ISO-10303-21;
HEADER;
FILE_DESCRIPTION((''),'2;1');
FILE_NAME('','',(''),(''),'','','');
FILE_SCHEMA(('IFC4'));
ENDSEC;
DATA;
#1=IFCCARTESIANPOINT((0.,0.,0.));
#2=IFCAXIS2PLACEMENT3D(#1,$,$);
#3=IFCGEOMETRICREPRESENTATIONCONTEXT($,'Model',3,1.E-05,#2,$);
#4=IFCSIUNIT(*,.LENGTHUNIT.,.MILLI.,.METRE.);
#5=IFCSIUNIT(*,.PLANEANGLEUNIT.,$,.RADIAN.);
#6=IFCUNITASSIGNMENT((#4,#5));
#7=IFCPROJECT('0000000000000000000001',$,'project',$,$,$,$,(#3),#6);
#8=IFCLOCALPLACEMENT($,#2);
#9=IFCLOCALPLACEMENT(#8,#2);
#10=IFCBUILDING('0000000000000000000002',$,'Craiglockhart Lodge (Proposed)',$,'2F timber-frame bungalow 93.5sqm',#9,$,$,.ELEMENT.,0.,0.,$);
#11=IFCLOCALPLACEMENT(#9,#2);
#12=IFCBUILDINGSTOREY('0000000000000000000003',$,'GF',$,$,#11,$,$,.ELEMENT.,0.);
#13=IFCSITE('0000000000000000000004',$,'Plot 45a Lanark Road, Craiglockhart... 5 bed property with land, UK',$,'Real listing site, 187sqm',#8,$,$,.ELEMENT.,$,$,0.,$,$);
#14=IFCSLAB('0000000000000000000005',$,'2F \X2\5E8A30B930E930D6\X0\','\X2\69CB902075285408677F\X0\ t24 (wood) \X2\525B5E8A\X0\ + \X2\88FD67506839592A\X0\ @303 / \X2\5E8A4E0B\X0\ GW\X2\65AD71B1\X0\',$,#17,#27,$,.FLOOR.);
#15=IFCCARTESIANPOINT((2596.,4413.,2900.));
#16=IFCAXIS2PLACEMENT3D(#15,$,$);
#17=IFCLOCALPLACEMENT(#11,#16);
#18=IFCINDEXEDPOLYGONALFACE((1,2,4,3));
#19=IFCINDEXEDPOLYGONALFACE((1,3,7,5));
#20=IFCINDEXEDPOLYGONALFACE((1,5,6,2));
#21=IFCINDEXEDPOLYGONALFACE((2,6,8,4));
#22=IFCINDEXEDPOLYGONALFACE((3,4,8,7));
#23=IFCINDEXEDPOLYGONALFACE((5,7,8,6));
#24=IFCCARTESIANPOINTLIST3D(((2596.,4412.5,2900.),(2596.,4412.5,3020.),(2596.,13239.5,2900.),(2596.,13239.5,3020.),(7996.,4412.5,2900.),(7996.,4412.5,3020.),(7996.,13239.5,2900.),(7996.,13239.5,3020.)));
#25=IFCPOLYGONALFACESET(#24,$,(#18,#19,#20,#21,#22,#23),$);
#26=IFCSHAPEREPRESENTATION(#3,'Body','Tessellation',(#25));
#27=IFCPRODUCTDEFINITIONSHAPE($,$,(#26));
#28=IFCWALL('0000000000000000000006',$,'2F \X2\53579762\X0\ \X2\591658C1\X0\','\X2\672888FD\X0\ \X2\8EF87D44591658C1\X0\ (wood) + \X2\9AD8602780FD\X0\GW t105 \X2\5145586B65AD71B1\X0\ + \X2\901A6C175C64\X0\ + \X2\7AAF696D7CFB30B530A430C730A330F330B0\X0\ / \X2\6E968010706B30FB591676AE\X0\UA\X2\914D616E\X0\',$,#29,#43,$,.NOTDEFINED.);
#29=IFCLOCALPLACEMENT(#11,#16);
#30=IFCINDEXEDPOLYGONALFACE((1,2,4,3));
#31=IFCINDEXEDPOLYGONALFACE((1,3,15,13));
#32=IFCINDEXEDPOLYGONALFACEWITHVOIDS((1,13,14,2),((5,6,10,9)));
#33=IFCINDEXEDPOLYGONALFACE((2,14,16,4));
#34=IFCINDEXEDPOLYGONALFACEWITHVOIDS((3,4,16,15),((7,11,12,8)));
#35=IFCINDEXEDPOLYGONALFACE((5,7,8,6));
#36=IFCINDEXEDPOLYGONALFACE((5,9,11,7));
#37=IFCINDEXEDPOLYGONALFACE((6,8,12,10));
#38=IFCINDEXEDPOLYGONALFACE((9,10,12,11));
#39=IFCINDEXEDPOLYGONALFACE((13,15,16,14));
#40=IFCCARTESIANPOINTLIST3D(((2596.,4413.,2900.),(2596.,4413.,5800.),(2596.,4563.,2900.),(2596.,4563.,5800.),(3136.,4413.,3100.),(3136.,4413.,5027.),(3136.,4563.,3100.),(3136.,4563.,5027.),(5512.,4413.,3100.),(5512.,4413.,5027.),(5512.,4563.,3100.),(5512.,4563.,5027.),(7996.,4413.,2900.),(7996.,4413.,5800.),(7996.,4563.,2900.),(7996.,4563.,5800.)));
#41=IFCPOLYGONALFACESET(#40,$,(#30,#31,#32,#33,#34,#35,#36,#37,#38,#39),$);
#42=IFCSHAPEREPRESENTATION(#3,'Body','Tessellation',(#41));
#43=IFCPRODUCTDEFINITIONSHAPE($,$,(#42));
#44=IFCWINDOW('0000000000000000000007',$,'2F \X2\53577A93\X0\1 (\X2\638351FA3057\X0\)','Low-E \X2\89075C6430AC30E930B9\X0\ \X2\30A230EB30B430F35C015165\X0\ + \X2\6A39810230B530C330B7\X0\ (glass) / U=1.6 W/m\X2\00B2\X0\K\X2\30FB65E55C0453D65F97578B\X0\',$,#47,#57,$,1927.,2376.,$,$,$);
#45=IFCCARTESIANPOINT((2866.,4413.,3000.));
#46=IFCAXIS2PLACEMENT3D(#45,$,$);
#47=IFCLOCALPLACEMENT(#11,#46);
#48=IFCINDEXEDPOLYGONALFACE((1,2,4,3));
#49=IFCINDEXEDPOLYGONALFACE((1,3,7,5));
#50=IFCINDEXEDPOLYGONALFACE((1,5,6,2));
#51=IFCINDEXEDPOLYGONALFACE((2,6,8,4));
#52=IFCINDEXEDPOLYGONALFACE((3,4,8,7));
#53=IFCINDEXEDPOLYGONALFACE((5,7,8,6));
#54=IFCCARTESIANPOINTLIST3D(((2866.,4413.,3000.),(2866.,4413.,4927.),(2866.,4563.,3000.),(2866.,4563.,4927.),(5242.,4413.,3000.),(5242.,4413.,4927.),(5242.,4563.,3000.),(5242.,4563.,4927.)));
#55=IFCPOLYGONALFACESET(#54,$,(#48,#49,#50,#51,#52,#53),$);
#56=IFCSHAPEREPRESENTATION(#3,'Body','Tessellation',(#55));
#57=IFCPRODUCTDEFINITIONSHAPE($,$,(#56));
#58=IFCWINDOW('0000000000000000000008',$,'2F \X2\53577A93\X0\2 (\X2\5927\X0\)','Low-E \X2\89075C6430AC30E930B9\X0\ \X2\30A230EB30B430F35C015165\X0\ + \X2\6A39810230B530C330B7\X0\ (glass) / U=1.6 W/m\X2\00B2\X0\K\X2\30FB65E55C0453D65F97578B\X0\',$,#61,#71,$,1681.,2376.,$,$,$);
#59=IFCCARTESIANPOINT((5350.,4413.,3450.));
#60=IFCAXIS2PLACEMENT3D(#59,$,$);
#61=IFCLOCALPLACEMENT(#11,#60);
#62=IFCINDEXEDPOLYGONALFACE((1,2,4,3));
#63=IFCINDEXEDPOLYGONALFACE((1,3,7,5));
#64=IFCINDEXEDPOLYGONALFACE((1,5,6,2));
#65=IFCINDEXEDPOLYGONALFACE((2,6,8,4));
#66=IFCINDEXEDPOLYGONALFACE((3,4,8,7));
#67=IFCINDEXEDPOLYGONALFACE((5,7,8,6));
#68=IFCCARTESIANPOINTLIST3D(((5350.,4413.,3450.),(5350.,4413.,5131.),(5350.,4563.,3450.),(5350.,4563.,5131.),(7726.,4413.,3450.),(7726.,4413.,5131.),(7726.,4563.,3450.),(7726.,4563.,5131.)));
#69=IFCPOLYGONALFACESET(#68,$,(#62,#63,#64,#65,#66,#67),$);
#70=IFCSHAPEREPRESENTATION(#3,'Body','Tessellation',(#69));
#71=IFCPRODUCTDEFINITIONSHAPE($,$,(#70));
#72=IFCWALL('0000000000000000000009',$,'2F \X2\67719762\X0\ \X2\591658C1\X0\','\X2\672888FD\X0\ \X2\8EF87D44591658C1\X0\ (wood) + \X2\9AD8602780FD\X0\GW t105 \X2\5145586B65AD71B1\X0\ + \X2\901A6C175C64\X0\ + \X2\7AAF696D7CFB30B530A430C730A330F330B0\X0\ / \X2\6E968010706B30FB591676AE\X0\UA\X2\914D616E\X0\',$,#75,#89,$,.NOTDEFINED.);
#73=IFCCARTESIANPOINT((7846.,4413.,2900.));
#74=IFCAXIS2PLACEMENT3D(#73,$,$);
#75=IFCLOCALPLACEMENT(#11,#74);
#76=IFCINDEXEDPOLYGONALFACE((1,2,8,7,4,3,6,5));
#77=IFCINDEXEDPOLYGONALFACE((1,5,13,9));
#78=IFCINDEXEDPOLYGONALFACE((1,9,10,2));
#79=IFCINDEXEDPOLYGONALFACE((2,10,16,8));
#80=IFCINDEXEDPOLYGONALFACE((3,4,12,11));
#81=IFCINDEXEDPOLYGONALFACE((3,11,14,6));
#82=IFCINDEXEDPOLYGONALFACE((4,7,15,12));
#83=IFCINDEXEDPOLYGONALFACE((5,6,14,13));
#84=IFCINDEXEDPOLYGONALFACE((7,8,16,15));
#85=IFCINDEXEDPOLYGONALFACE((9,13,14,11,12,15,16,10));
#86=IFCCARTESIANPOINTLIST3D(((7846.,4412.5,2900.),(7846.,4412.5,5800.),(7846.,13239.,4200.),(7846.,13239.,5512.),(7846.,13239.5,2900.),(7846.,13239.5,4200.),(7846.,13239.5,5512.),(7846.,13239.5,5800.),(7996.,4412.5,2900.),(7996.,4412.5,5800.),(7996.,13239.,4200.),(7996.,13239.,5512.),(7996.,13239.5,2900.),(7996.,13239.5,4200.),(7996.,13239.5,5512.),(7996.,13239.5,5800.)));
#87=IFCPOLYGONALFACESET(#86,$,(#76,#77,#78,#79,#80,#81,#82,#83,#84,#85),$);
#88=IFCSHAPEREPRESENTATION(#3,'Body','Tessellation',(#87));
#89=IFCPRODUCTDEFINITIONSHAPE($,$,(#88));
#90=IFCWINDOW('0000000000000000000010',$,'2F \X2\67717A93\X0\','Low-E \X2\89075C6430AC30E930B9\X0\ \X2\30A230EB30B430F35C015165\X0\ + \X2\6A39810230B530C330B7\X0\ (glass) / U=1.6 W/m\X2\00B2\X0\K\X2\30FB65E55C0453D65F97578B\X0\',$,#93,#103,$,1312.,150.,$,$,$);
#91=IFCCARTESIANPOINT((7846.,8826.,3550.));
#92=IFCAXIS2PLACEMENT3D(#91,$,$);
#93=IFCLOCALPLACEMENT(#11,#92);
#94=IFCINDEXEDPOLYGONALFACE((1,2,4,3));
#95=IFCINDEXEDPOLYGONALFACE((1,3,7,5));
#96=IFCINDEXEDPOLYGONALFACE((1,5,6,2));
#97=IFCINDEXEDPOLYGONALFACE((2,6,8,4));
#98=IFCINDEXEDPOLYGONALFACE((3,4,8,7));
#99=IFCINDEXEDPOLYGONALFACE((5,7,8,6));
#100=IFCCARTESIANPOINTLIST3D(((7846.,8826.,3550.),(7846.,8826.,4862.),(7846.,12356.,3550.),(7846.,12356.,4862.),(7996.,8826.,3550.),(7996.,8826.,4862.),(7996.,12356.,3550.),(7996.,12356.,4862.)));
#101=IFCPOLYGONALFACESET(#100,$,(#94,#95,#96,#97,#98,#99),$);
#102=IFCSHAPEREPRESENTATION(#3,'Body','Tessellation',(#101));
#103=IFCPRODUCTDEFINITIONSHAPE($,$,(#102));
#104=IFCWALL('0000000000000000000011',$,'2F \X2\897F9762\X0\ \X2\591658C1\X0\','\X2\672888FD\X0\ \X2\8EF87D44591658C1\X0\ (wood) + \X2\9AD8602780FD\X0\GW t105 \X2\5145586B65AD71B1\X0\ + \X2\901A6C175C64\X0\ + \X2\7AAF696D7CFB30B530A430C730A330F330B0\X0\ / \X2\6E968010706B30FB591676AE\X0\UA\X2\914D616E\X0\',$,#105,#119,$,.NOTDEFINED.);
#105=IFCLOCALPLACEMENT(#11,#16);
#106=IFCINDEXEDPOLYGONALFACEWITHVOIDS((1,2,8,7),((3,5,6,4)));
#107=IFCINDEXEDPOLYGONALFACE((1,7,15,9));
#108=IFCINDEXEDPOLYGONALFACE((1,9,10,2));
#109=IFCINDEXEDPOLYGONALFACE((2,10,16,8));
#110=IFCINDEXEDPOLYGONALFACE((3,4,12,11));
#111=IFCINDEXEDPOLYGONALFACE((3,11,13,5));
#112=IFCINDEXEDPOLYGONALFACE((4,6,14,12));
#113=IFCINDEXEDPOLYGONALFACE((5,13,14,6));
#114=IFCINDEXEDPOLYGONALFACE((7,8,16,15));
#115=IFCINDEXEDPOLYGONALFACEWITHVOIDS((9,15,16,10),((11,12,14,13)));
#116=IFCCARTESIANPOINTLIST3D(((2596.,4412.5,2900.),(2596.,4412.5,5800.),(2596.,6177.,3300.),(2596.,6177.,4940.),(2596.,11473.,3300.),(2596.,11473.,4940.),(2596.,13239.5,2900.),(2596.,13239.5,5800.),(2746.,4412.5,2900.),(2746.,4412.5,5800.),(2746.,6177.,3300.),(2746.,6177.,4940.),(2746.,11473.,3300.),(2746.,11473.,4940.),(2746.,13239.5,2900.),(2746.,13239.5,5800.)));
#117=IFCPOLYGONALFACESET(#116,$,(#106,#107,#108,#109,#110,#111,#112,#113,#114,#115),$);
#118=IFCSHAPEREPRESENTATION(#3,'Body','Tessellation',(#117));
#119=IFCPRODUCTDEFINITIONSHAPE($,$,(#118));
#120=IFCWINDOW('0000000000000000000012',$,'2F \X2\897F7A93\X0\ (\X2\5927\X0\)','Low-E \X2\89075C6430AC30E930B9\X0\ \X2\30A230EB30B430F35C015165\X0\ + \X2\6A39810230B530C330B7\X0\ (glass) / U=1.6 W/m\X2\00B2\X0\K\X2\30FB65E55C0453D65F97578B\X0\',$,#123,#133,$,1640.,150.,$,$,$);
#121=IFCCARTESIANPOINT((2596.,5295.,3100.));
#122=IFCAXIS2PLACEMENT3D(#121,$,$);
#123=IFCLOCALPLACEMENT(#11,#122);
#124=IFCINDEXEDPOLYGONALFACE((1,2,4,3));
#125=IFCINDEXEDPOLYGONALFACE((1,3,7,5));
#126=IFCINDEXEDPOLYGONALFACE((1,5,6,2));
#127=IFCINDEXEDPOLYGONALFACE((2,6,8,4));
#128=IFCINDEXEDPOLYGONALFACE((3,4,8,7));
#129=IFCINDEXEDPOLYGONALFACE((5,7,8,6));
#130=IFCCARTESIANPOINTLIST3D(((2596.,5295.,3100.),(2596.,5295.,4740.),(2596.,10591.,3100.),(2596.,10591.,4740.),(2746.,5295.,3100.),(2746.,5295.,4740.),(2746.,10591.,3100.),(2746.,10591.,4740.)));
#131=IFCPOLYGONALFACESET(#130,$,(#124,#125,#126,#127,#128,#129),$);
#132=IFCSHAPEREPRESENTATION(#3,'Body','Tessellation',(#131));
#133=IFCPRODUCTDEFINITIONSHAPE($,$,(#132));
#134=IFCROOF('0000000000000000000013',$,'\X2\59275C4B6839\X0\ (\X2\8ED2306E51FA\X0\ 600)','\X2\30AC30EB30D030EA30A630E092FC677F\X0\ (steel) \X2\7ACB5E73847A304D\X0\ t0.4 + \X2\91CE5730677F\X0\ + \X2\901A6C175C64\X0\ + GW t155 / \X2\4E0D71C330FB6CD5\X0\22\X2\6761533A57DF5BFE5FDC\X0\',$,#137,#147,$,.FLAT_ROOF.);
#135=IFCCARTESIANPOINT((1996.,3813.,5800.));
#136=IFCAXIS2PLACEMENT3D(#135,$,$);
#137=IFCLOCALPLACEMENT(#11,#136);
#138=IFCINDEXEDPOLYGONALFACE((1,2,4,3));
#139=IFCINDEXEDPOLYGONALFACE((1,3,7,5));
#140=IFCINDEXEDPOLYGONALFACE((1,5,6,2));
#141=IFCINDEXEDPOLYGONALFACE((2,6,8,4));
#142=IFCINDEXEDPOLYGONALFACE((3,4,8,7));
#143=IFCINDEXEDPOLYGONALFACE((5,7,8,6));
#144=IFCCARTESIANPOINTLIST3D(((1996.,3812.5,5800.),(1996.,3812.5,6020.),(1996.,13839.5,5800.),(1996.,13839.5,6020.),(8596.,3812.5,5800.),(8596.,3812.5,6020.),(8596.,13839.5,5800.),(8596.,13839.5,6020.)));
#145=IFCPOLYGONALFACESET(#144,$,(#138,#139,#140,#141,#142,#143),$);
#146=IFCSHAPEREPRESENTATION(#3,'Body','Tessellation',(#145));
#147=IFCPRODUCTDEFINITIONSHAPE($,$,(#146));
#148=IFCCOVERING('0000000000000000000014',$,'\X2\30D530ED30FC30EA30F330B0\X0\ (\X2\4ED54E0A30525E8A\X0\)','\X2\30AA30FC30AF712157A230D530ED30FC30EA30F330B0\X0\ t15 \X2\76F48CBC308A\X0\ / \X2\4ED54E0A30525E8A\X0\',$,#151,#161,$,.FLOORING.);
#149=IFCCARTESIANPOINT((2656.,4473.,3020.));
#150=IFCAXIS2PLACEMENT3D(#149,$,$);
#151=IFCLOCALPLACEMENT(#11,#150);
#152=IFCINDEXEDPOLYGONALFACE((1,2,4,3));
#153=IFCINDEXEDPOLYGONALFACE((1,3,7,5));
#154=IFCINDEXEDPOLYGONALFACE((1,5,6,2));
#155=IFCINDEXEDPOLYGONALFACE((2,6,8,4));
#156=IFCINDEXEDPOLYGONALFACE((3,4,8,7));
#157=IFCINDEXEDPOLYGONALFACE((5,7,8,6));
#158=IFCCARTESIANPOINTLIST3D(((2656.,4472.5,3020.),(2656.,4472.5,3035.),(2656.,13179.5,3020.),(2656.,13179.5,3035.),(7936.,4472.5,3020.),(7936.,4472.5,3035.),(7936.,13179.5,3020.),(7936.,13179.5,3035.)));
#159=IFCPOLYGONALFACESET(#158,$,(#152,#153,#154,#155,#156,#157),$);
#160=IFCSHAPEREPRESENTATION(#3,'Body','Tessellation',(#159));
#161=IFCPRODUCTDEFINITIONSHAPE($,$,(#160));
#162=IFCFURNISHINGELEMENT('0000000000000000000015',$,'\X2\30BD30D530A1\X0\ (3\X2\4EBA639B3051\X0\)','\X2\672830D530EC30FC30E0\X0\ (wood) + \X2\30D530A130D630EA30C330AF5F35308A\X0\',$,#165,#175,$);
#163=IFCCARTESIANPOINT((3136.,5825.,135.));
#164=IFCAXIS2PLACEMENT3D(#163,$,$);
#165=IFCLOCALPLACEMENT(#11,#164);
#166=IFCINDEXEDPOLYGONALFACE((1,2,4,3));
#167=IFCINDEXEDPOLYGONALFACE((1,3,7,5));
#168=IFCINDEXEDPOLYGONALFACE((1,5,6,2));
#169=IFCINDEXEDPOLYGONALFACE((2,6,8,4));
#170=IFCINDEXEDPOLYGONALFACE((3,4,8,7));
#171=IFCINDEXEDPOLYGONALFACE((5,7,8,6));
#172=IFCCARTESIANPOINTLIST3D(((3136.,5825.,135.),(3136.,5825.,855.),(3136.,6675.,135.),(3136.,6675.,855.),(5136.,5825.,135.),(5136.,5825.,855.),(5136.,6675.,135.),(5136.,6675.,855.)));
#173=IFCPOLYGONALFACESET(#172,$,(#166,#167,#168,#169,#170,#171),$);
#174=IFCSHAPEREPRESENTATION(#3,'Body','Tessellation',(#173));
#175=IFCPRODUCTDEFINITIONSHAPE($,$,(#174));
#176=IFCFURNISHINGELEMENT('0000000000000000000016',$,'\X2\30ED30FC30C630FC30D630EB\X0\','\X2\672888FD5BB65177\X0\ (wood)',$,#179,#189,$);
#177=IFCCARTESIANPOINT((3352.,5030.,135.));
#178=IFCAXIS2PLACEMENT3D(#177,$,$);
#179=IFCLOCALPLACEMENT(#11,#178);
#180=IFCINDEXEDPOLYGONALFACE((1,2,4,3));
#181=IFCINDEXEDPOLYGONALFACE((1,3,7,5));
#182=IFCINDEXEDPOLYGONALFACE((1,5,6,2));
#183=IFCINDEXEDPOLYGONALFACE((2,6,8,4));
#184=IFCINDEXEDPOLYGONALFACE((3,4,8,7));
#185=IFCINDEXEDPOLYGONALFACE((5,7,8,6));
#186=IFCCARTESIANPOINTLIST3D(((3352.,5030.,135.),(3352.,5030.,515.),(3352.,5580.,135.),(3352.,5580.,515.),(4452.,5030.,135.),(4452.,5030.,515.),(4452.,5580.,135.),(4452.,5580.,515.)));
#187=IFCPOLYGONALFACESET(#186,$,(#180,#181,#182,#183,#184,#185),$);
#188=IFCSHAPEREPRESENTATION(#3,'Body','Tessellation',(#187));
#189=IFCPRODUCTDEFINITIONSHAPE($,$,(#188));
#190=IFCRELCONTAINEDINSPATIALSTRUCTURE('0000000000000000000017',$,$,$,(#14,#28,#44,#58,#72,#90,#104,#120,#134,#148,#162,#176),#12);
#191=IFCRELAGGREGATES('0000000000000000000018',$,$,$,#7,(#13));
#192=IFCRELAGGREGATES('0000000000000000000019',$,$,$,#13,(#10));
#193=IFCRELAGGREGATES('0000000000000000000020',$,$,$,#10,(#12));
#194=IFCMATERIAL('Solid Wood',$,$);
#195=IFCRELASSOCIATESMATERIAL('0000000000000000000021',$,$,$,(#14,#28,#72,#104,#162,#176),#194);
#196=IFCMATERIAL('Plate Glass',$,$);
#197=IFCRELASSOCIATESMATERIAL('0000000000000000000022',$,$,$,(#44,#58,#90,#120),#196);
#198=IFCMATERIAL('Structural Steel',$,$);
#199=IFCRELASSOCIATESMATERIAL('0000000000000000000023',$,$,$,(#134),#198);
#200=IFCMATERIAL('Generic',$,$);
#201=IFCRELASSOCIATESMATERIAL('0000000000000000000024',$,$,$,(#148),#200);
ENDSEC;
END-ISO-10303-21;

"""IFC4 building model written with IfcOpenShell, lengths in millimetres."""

from ifc_helpers import new_model, si_unit, frame, frame_2d, origin, place, context, project, spatial, rectangle, extrude, material, element, fill, save


model = new_model("IFC4")

# Units and contexts
model_context = context("Model", 3, precision=1e-05, world=origin())
ifc_project = project(units=[si_unit("LENGTHUNIT", "METRE", prefix="MILLI"), si_unit("PLANEANGLEUNIT", "RADIAN")], contexts=[model_context])

# Site, building, storey
site_placement = place(None, origin())
site = spatial("IfcSite", under=ifc_project, at=site_placement, Name="Plot 45a Lanark Road, Craiglockhart... 5 bed property with land, UK", ObjectType="Real listing site, 187sqm", CompositionType="ELEMENT", RefElevation=0.0)
building_placement = place(site_placement, origin())
building = spatial("IfcBuilding", under=site, at=building_placement, Name="Craiglockhart Lodge (Proposed)", ObjectType="2F timber-frame bungalow 93.5sqm", CompositionType="ELEMENT", ElevationOfRefHeight=0.0, ElevationOfTerrain=0.0)
storey_placement = place(building_placement, origin())
storey = spatial("IfcBuildingStorey", under=building, at=storey_placement, Name="GF", CompositionType="ELEMENT", Elevation=0.0)

# Slab
ifc_material_1 = material(Name="Solid Wood")
slab_placement = place(storey_placement, frame((2596.0, 4413.0, 2900.0)))
element("IfcSlab", 1, at=slab_placement, inside=storey, material=ifc_material_1, Name="2F 床スラブ", Description="構造用合板 t24 (wood) 剛床 + 製材根太 @303 / 床下 GW断熱", PredefinedType="FLOOR", context=model_context, shape_type="SweptSolid", body=[
    extrude(rectangle(XDim=5400.0, YDim=8827.0, at=frame_2d((2700.0, 4413.0))), frame((2596.0, 4413.0, 2900.0)), (0.0, 0.0, 1.0), 120.0),
])

# Wall, openings, windows
wall_1_placement = place(storey_placement, frame((2596.0, 4413.0, 2900.0)))
wall_1 = element("IfcWall", 2, at=wall_1_placement, inside=storey, material=ifc_material_1, Name="2F 南面 外壁", Description="木製 軸組外壁 (wood) + 高性能GW t105 充填断熱 + 通気層 + 窯業系サイディング / 準耐火・外皮UA配慮", PredefinedType="NOTDEFINED", context=model_context, shape_type="SweptSolid", body=[
    extrude(rectangle(XDim=5400.0, YDim=150.0, at=frame_2d((2700.0, 75.0))), frame((2596.0, 4413.0, 2900.0)), (0.0, 0.0, 1.0), 2900.0),
])
opening_1_placement = place(storey_placement, frame((2866.0, 4413.0, 3000.0)))
opening_1 = element("IfcOpeningElement", 3, at=opening_1_placement, cuts=wall_1, PredefinedType="NOTDEFINED", context=model_context, shape_type="SweptSolid", body=[
    extrude(rectangle(XDim=2376.0, YDim=150.0, at=frame_2d((1188.0, 75.0))), frame((2866.0, 4413.0, 3000.0)), (0.0, 0.0, 1.0), 1927.0),
])
opening_2_placement = place(storey_placement, frame((5350.0, 4413.0, 3450.0)))
opening_2 = element("IfcOpeningElement", 4, at=opening_2_placement, cuts=wall_1, PredefinedType="NOTDEFINED", context=model_context, shape_type="SweptSolid", body=[
    extrude(rectangle(XDim=2376.0, YDim=150.0, at=frame_2d((1188.0, 75.0))), frame((5350.0, 4413.0, 3450.0)), (0.0, 0.0, 1.0), 1681.0),
])
ifc_material_2 = material(Name="Plate Glass")
window_1_placement = place(storey_placement, frame((2866.0, 4413.0, 3000.0)))
window_1 = element("IfcWindow", 5, at=window_1_placement, inside=storey, material=ifc_material_2, Name="2F 南窓1 (掃出し)", Description="Low-E 複層ガラス アルゴン封入 + 樹脂サッシ (glass) / U=1.6 W/m²K・日射取得型", OverallHeight=1927.0, OverallWidth=2376.0, context=model_context, shape_type="SweptSolid", body=[
    extrude(rectangle(XDim=2376.0, YDim=150.0, at=frame_2d((1188.0, 75.0))), frame((2866.0, 4413.0, 3000.0)), (0.0, 0.0, 1.0), 1927.0),
])
fill(opening_1, window_1)
window_2_placement = place(storey_placement, frame((5350.0, 4413.0, 3450.0)))
window_2 = element("IfcWindow", 6, at=window_2_placement, inside=storey, material=ifc_material_2, Name="2F 南窓2 (大)", Description="Low-E 複層ガラス アルゴン封入 + 樹脂サッシ (glass) / U=1.6 W/m²K・日射取得型", OverallHeight=1681.0, OverallWidth=2376.0, context=model_context, shape_type="SweptSolid", body=[
    extrude(rectangle(XDim=2376.0, YDim=150.0, at=frame_2d((1188.0, 75.0))), frame((5350.0, 4413.0, 3450.0)), (0.0, 0.0, 1.0), 1681.0),
])
fill(opening_2, window_2)

# Walls, openings, windows
wall_2_placement = place(storey_placement, frame((7846.0, 4413.0, 2900.0)))
wall_2 = element("IfcWall", 7, at=wall_2_placement, inside=storey, material=ifc_material_1, Name="2F 東面 外壁", Description="木製 軸組外壁 (wood) + 高性能GW t105 充填断熱 + 通気層 + 窯業系サイディング / 準耐火・外皮UA配慮", PredefinedType="NOTDEFINED", context=model_context, shape_type="SweptSolid", body=[
    extrude(rectangle(XDim=150.0, YDim=8827.0, at=frame_2d((75.0, 4413.0))), frame((7846.0, 4413.0, 2900.0)), (0.0, 0.0, 1.0), 2900.0),
])
opening_3_placement = place(storey_placement, frame((7846.0, 8826.0, 3550.0)))
opening_3 = element("IfcOpeningElement", 8, at=opening_3_placement, cuts=wall_2, PredefinedType="NOTDEFINED", context=model_context, shape_type="SweptSolid", body=[
    extrude(rectangle(XDim=150.0, YDim=3530.0, at=frame_2d((75.0, 1765.0))), frame((7846.0, 8826.0, 3550.0)), (0.0, 0.0, 1.0), 1312.0),
])
window_3_placement = place(storey_placement, frame((7846.0, 8826.0, 3550.0)))
window_3 = element("IfcWindow", 9, at=window_3_placement, inside=storey, material=ifc_material_2, Name="2F 東窓", Description="Low-E 複層ガラス アルゴン封入 + 樹脂サッシ (glass) / U=1.6 W/m²K・日射取得型", OverallHeight=1312.0, OverallWidth=150.0, context=model_context, shape_type="SweptSolid", body=[
    extrude(rectangle(XDim=150.0, YDim=3530.0, at=frame_2d((75.0, 1765.0))), frame((7846.0, 8826.0, 3550.0)), (0.0, 0.0, 1.0), 1312.0),
])
fill(opening_3, window_3)
wall_3_placement = place(storey_placement, frame((2596.0, 4413.0, 2900.0)))
wall_3 = element("IfcWall", 10, at=wall_3_placement, inside=storey, material=ifc_material_1, Name="2F 西面 外壁", Description="木製 軸組外壁 (wood) + 高性能GW t105 充填断熱 + 通気層 + 窯業系サイディング / 準耐火・外皮UA配慮", PredefinedType="NOTDEFINED", context=model_context, shape_type="SweptSolid", body=[
    extrude(rectangle(XDim=150.0, YDim=8827.0, at=frame_2d((75.0, 4413.0))), frame((2596.0, 4413.0, 2900.0)), (0.0, 0.0, 1.0), 2900.0),
])
opening_4_placement = place(storey_placement, frame((2596.0, 5295.0, 3100.0)))
opening_4 = element("IfcOpeningElement", 11, at=opening_4_placement, cuts=wall_3, PredefinedType="NOTDEFINED", context=model_context, shape_type="SweptSolid", body=[
    extrude(rectangle(XDim=150.0, YDim=5296.0, at=frame_2d((75.0, 2648.0))), frame((2596.0, 5295.0, 3100.0)), (0.0, 0.0, 1.0), 1640.0),
])
window_4_placement = place(storey_placement, frame((2596.0, 5295.0, 3100.0)))
window_4 = element("IfcWindow", 12, at=window_4_placement, inside=storey, material=ifc_material_2, Name="2F 西窓 (大)", Description="Low-E 複層ガラス アルゴン封入 + 樹脂サッシ (glass) / U=1.6 W/m²K・日射取得型", OverallHeight=1640.0, OverallWidth=150.0, context=model_context, shape_type="SweptSolid", body=[
    extrude(rectangle(XDim=150.0, YDim=5296.0, at=frame_2d((75.0, 2648.0))), frame((2596.0, 5295.0, 3100.0)), (0.0, 0.0, 1.0), 1640.0),
])
fill(opening_4, window_4)

# Roof
ifc_material_3 = material(Name="Structural Steel")
roof_placement = place(storey_placement, frame((1996.0, 3813.0, 5800.0)))
element("IfcRoof", 13, at=roof_placement, inside=storey, material=ifc_material_3, Name="大屋根 (軒の出 600)", Description="ガルバリウム鋼板 (steel) 立平葺き t0.4 + 野地板 + 通気層 + GW t155 / 不燃・法22条区域対応", PredefinedType="FLAT_ROOF", context=model_context, shape_type="SweptSolid", body=[
    extrude(rectangle(XDim=6600.0, YDim=10027.0, at=frame_2d((3300.0, 5013.0))), frame((1996.0, 3813.0, 5800.0)), (0.0, 0.0, 1.0), 220.0),
])

# Covering
ifc_material_4 = material(Name="Generic")
covering_placement = place(storey_placement, frame((2656.0, 4473.0, 3020.0)))
element("IfcCovering", 14, at=covering_placement, inside=storey, material=ifc_material_4, Name="フローリング (仕上げ床)", Description="オーク無垢フローリング t15 直貼り / 仕上げ床", PredefinedType="FLOORING", context=model_context, shape_type="SweptSolid", body=[
    extrude(rectangle(XDim=5280.0, YDim=8707.0, at=frame_2d((2640.0, 4353.0))), frame((2656.0, 4473.0, 3020.0)), (0.0, 0.0, 1.0), 15.0),
])

# Furnishing elements
furnishing_1_placement = place(storey_placement, frame((3136.0, 5825.0, 135.0)))
element("IfcFurnishingElement", 15, at=furnishing_1_placement, inside=storey, material=ifc_material_1, Name="ソファ (3人掛け)", Description="木フレーム (wood) + ファブリック張り", context=model_context, shape_type="SweptSolid", body=[
    extrude(rectangle(XDim=2000.0, YDim=850.0, at=frame_2d((1000.0, 425.0))), frame((3136.0, 5825.0, 135.0)), (0.0, 0.0, 1.0), 720.0),
])
furnishing_2_placement = place(storey_placement, frame((3352.0, 5030.0, 135.0)))
element("IfcFurnishingElement", 16, at=furnishing_2_placement, inside=storey, material=ifc_material_1, Name="ローテーブル", Description="木製家具 (wood)", context=model_context, shape_type="SweptSolid", body=[
    extrude(rectangle(XDim=1100.0, YDim=550.0, at=frame_2d((550.0, 275.0))), frame((3352.0, 5030.0, 135.0)), (0.0, 0.0, 1.0), 380.0),
])

save(model, "model.ifc")
